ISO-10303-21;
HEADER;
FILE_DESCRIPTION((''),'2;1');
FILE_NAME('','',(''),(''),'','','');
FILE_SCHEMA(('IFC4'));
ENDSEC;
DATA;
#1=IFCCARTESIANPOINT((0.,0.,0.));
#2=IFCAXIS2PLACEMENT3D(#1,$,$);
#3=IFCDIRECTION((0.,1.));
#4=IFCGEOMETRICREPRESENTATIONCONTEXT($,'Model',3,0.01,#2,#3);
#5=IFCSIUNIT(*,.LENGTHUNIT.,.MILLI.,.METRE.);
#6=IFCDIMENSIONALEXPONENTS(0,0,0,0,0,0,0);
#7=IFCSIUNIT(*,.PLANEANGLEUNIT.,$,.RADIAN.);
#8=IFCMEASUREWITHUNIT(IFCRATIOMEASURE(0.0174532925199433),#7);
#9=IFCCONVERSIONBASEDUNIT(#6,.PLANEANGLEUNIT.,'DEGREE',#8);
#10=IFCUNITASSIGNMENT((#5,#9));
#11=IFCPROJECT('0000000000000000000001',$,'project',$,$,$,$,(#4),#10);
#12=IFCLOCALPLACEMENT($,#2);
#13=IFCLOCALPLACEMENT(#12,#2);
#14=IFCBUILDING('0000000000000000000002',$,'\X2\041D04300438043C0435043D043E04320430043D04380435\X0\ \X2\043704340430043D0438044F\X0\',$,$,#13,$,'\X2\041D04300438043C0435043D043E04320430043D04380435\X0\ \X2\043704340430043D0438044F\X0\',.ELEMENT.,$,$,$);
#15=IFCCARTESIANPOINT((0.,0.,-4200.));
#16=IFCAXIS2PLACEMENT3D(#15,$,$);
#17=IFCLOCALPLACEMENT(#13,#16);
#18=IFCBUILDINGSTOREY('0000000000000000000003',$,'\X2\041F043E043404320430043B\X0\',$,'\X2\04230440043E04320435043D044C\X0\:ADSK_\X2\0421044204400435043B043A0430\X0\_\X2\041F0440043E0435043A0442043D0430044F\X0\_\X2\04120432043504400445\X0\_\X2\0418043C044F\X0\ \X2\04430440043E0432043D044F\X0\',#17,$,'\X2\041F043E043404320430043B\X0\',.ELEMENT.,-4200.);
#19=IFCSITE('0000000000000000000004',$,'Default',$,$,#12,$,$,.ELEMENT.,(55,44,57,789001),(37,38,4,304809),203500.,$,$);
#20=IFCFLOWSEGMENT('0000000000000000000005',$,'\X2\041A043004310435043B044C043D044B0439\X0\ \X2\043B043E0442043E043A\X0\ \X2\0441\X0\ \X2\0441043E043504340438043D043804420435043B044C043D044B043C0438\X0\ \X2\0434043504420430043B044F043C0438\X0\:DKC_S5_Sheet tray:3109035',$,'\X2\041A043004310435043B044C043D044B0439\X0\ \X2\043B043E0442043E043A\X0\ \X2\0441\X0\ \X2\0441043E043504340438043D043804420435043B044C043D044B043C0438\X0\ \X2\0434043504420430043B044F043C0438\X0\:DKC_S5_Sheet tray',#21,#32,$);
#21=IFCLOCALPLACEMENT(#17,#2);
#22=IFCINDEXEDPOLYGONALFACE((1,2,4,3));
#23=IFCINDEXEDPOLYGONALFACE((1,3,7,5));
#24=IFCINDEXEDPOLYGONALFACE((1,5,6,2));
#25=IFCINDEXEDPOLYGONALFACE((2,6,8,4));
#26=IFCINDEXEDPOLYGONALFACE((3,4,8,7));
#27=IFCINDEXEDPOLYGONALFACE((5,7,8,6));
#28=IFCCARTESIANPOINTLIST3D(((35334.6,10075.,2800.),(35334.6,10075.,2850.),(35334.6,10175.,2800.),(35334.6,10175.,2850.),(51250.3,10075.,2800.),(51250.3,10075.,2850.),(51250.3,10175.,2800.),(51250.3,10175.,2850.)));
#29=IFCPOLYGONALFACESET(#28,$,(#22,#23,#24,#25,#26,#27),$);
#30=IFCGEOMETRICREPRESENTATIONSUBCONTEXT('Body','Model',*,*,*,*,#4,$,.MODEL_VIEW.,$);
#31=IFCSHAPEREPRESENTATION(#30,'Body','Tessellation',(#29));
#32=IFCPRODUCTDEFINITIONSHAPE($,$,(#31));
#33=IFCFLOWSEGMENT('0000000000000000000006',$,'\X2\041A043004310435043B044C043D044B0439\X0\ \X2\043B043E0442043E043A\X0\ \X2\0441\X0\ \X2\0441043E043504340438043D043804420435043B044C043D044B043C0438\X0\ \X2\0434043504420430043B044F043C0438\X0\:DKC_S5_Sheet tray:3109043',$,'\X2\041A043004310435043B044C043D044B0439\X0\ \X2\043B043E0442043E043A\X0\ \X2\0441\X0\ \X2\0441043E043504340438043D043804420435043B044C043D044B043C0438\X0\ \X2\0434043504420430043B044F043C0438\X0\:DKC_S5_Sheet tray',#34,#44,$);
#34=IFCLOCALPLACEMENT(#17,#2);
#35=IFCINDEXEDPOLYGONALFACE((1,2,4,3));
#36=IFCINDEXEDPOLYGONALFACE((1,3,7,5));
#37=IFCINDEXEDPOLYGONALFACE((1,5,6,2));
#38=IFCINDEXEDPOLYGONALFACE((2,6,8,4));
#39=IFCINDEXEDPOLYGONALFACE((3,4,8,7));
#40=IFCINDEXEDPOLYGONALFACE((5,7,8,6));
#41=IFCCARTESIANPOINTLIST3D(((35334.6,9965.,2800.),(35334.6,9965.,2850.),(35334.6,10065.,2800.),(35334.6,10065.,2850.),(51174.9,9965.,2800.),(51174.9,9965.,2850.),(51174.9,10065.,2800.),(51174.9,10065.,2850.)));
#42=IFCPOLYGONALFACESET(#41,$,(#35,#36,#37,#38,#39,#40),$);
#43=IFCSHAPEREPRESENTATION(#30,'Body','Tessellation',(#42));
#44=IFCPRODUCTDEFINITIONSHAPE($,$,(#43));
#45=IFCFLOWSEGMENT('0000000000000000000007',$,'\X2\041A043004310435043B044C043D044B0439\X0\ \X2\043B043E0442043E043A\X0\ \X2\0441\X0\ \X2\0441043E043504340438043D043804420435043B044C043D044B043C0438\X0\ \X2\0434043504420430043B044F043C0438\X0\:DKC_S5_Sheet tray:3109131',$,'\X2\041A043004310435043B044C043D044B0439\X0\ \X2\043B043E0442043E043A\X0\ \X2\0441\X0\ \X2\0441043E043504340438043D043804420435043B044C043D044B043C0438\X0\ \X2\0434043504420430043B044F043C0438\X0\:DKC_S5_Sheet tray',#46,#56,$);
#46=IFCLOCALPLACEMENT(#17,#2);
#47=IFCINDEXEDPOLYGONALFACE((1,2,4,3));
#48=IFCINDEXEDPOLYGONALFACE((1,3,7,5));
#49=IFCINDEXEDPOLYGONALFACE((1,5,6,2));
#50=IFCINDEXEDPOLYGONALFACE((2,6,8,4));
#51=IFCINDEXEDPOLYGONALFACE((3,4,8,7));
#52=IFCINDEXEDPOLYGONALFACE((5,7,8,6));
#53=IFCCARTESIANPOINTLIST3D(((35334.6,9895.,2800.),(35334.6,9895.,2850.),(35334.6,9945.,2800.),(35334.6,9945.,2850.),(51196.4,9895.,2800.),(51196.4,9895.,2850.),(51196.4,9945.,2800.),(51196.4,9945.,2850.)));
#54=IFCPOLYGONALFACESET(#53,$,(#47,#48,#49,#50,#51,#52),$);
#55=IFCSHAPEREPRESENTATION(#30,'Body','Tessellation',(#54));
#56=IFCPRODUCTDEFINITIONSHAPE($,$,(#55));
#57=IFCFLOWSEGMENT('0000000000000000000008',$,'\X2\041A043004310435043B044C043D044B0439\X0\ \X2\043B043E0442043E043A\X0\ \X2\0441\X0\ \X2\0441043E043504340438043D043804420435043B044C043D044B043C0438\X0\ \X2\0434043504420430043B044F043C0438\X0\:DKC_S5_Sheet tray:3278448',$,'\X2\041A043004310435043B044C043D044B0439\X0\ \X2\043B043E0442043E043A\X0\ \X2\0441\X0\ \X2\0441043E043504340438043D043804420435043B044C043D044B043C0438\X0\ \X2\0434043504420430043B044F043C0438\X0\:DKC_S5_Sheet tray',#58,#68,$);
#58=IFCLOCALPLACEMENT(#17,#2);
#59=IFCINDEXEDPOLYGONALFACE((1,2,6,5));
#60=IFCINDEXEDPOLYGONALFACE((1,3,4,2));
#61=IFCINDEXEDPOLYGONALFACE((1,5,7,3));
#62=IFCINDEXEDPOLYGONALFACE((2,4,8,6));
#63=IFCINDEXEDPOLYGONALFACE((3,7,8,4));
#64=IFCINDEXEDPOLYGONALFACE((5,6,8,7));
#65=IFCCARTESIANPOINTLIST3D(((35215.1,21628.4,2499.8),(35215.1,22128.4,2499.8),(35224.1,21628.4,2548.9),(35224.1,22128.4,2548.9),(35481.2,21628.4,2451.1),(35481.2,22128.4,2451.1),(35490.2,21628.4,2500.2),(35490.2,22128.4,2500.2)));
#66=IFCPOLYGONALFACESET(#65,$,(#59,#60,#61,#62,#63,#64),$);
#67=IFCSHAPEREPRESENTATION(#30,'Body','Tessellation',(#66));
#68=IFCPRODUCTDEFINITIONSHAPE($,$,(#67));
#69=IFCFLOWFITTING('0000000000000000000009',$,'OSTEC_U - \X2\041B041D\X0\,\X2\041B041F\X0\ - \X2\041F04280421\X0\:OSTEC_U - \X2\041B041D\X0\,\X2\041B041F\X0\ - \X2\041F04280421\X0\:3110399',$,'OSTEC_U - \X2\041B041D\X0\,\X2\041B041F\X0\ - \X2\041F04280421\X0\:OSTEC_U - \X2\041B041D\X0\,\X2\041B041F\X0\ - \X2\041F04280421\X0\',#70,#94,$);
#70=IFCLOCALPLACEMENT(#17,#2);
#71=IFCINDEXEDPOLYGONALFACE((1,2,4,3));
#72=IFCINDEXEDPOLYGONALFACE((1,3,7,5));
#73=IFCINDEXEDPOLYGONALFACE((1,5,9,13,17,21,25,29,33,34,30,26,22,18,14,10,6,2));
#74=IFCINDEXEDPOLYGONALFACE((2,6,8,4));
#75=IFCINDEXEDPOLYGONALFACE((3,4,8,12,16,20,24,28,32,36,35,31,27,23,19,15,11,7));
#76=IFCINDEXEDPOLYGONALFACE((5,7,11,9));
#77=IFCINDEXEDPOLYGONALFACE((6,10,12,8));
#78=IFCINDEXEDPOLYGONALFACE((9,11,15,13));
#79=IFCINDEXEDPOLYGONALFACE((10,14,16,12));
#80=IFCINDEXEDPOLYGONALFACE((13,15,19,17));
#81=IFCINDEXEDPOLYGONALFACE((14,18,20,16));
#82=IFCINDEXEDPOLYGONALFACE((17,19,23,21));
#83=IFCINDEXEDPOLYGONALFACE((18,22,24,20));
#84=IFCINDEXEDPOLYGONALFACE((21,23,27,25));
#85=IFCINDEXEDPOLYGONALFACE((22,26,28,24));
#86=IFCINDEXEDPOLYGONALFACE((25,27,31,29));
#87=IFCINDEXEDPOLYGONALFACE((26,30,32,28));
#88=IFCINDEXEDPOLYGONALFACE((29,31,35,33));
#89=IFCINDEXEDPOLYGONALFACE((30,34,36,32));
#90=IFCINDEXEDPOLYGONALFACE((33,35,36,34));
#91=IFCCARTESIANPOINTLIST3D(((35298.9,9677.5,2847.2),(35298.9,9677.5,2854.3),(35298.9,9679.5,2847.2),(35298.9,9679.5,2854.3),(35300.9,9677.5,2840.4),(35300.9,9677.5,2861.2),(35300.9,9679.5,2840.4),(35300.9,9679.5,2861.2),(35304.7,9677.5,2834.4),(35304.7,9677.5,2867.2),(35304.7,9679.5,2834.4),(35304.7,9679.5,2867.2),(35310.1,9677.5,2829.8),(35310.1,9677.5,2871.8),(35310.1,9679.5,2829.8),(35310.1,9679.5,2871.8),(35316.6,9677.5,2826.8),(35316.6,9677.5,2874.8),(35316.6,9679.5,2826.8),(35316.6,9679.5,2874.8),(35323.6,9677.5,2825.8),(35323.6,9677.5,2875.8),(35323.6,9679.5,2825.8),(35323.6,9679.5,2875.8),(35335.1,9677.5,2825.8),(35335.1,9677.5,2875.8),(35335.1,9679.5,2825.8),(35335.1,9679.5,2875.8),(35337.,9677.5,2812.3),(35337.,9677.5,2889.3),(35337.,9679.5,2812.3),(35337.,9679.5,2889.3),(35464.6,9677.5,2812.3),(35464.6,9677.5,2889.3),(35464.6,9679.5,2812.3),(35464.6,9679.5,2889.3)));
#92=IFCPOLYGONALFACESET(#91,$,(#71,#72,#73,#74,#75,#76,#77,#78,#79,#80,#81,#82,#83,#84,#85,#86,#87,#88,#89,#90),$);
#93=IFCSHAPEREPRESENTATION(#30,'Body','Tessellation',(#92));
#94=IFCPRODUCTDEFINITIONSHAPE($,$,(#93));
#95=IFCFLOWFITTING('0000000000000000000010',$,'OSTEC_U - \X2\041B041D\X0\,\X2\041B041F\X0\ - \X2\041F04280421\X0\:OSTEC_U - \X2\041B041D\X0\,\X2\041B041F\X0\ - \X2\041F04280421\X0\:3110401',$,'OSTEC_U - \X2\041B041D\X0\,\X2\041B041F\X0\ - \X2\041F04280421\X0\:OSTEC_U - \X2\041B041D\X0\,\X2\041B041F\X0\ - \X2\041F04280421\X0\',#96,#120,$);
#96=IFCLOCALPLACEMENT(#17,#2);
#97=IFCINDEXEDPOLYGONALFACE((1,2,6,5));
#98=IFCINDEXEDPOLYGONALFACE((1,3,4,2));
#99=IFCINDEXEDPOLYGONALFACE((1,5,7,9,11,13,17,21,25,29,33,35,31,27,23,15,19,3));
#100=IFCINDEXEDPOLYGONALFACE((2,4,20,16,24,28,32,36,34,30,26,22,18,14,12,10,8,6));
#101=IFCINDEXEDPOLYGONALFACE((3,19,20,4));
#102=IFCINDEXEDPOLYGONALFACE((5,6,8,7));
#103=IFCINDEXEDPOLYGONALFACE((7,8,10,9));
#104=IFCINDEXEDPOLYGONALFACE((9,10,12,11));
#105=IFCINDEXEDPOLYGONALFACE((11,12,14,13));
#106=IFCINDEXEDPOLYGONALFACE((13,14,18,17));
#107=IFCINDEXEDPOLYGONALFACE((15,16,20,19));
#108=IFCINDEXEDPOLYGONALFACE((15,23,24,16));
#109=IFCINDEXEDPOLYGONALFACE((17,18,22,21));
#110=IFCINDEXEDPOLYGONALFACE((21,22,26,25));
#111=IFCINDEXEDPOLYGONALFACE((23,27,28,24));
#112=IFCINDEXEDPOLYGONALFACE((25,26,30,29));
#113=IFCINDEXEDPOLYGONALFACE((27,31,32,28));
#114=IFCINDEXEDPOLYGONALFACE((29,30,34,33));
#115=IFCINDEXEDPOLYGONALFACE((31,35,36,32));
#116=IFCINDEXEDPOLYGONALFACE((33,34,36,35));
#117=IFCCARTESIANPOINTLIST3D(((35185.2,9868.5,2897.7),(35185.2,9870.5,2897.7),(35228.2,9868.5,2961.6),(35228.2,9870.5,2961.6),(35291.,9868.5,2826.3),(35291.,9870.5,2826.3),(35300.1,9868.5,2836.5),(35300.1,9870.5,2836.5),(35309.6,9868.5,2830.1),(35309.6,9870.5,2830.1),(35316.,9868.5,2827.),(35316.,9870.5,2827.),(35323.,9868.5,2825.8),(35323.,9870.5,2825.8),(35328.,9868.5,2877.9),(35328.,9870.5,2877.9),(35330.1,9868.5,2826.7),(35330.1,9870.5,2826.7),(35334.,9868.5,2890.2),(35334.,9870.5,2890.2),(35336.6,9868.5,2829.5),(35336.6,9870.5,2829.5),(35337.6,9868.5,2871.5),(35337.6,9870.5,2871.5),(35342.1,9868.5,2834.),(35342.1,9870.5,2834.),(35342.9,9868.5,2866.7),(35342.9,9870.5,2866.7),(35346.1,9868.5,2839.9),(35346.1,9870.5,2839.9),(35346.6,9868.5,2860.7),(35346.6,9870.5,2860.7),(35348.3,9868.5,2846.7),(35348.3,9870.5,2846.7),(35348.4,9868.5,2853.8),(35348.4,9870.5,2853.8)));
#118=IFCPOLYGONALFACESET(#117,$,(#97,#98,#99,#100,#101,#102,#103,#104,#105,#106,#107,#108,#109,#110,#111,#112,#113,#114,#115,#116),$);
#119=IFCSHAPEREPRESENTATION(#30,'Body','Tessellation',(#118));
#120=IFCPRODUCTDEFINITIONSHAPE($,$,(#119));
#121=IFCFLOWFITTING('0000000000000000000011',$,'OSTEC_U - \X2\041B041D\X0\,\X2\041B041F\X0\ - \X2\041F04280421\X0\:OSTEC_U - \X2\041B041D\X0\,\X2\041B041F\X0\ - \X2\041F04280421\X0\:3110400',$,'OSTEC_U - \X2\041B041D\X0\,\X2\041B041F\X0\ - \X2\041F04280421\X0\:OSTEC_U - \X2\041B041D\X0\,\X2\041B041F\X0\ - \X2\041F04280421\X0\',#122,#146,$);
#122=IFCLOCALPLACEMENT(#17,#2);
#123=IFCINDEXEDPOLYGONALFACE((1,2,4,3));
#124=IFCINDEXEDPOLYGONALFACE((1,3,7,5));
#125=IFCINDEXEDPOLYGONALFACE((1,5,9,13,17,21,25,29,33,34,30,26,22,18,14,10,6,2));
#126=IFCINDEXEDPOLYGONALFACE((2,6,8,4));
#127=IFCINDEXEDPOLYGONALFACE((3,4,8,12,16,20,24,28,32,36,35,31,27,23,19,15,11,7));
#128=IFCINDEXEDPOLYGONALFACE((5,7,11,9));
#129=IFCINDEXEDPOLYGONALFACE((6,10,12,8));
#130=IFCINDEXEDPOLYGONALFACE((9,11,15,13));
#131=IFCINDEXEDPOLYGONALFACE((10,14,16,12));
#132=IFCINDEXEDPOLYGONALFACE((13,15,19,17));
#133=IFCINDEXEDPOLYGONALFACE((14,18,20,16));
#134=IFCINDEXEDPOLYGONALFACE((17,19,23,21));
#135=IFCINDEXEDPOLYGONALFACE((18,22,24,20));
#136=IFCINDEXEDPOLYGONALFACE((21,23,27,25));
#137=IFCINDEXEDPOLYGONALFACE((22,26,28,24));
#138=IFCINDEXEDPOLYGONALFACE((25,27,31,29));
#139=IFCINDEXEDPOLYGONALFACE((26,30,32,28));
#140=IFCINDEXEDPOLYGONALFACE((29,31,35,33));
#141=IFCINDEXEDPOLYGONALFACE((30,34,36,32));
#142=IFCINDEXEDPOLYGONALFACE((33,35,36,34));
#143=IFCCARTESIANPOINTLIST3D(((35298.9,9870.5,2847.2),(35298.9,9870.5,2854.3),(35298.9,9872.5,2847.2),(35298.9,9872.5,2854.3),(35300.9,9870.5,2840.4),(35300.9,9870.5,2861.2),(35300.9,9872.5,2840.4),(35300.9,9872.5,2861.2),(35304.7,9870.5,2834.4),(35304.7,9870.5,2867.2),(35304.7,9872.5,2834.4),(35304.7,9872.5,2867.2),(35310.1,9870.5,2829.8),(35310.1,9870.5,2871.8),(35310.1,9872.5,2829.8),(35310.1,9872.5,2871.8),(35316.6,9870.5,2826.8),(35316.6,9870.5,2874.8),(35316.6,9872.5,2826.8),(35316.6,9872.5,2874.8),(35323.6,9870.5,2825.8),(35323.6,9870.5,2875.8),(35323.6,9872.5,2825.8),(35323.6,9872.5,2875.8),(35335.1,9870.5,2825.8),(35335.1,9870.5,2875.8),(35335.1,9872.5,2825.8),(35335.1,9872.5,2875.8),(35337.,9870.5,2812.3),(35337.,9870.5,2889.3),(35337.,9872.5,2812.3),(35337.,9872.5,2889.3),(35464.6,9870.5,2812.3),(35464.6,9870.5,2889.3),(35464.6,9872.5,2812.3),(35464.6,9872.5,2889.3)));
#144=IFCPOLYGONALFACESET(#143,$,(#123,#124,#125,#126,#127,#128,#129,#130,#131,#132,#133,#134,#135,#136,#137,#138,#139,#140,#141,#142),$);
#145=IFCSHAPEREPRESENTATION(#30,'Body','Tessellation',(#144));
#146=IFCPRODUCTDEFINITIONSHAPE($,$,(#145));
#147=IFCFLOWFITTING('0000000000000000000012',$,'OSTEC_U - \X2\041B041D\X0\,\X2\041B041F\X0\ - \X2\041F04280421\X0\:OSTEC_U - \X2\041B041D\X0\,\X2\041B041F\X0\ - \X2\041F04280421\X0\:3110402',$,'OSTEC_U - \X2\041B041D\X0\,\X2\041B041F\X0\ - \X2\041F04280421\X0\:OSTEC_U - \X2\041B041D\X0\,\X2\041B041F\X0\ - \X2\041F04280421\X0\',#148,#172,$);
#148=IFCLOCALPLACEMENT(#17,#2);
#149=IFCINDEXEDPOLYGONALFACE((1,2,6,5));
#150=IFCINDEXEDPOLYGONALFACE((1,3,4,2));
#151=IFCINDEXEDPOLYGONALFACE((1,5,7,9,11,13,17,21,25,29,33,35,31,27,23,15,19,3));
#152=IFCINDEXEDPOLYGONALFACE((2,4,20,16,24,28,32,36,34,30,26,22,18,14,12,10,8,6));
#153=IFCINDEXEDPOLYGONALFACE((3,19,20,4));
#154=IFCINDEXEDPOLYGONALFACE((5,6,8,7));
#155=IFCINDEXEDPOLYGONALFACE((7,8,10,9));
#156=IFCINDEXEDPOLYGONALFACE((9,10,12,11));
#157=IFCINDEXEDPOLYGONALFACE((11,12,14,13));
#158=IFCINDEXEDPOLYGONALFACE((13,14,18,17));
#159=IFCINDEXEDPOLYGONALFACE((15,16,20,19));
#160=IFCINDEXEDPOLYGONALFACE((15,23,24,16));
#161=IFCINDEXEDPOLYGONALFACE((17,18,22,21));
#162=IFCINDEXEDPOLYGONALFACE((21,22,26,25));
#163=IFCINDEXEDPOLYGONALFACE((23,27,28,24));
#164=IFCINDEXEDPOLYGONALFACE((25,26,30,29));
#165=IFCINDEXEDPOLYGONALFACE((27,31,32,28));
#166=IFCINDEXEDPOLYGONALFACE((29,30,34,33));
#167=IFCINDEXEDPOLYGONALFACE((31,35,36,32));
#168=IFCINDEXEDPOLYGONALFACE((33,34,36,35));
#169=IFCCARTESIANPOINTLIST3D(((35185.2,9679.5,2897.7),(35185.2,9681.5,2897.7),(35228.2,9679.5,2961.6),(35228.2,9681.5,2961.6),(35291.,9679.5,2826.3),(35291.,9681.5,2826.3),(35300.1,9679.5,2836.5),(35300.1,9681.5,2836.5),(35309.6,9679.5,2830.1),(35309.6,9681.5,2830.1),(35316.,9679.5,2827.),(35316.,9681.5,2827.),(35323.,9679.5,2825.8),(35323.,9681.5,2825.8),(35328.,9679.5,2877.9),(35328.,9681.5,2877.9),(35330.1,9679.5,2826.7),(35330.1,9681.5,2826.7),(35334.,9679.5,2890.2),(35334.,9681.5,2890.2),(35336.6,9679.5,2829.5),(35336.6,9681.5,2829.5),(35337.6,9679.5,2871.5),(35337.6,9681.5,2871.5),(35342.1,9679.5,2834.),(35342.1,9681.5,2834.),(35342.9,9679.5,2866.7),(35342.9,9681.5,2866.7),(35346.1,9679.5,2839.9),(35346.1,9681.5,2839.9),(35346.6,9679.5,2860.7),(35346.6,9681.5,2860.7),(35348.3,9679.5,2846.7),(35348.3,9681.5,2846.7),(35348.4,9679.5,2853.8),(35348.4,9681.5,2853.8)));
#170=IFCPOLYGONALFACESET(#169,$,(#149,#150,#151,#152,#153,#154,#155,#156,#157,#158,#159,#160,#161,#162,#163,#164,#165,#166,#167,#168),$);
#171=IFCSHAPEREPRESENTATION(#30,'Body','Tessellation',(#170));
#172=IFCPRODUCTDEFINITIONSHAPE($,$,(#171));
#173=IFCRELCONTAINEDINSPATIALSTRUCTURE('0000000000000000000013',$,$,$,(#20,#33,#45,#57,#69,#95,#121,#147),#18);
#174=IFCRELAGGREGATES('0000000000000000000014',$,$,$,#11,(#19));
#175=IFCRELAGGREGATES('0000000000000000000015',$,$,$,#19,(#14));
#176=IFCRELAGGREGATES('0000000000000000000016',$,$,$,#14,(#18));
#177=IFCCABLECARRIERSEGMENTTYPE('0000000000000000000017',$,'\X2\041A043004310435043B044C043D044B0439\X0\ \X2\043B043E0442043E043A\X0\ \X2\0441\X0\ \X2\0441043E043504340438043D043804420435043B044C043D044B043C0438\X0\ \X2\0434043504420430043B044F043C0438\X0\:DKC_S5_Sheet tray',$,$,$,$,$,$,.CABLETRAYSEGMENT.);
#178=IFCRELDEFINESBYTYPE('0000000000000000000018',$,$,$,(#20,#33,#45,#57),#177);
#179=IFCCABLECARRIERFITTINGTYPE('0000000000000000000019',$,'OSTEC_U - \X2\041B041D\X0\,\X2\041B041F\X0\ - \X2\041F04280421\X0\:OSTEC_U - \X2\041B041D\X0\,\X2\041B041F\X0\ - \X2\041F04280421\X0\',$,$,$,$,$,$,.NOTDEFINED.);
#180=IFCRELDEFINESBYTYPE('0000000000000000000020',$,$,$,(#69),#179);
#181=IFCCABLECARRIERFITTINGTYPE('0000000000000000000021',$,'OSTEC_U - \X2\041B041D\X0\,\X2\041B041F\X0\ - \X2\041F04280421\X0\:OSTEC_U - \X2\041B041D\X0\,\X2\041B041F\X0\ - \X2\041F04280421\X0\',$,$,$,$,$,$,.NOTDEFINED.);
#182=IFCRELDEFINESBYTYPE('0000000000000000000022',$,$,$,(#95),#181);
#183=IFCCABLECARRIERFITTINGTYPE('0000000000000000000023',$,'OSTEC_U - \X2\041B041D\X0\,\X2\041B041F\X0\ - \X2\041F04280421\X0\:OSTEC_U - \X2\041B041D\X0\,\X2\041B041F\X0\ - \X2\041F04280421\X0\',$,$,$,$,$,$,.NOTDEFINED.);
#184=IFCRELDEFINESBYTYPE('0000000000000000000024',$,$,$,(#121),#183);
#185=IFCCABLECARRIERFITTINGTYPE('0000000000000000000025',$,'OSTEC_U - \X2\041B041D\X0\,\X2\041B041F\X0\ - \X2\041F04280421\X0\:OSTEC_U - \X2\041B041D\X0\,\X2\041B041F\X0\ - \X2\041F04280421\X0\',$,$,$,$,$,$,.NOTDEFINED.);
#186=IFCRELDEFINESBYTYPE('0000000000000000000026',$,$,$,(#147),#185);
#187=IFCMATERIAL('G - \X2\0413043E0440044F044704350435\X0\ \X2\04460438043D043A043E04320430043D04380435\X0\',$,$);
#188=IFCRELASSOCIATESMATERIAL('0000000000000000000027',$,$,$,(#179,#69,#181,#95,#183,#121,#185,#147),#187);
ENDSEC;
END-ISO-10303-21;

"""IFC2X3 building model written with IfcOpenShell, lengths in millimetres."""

from ifc_helpers import new_model, entity, si_unit, converted_unit, direction, frame, frame_2d, origin, origin_2d_with_axis, place, context, subcontext, project, spatial, polyline, circle_curve, parameter, trimmed, segment, composite_curve, rectangle, outline, extrude, source, transform, mapped, material, type_object, type_shapes, element, save


model = new_model("IFC2X3")

# Units and contexts
model_context = context("Model", 3, precision=0.01, world=origin(), true_north=direction((0.0, 1.0)))
body_context = subcontext(model_context, "Body", "Model", "MODEL_VIEW")
ifc_project = project(units=[si_unit("LENGTHUNIT", "METRE", prefix="MILLI"), converted_unit("PLANEANGLEUNIT", "DEGREE", entity("IfcRatioMeasure", 0.0174532925199433), si_unit("PLANEANGLEUNIT", "RADIAN"), dimensions=[0, 0, 0, 0, 0, 0, 0])], contexts=[model_context])

# Site, building, storey
site_placement = place(None, origin())
site = spatial("IfcSite", under=ifc_project, at=site_placement, Name="Default", CompositionType="ELEMENT", RefLatitude=(55, 44, 57, 789001), RefLongitude=(37, 38, 4, 304809), RefElevation=203500.0)
building_placement = place(site_placement, origin())
building = spatial("IfcBuilding", under=site, at=building_placement, Name="Наименование здания", LongName="Наименование здания", CompositionType="ELEMENT")
storey_placement = place(building_placement, frame((0.0, 0.0, -4200.0)))
storey = spatial("IfcBuildingStorey", under=building, at=storey_placement, Name="Подвал", ObjectType="Уровень:ADSK_Стрелка_Проектная_Вверх_Имя уровня", LongName="Подвал", CompositionType="ELEMENT", Elevation=-4200.0)

# Flow segments
cable_carrier_segment_type = type_object("IfcCableCarrierSegmentType", Name="Кабельный лоток с соединительными деталями:DKC_S5_Sheet tray", PredefinedType="CABLETRAYSEGMENT")
flow_segment_1_placement = place(storey_placement, frame((35334.6, 10075.0, 2800.0)))
element("IfcFlowSegment", 1, at=flow_segment_1_placement, inside=storey, type_object=cable_carrier_segment_type, Name="Кабельный лоток с соединительными деталями:DKC_S5_Sheet tray:3109035", ObjectType="Кабельный лоток с соединительными деталями:DKC_S5_Sheet tray", context=body_context, shape_type="SweptSolid", body=[
    extrude(rectangle(XDim=15915.7, YDim=100.0, at=origin_2d_with_axis()), frame((7957.8, 50.0, 0.0)), (0.0, 0.0, 1.0), 50.0),
])
flow_segment_2_placement = place(storey_placement, frame((35334.6, 9965.0, 2800.0)))
element("IfcFlowSegment", 2, at=flow_segment_2_placement, inside=storey, type_object=cable_carrier_segment_type, Name="Кабельный лоток с соединительными деталями:DKC_S5_Sheet tray:3109043", ObjectType="Кабельный лоток с соединительными деталями:DKC_S5_Sheet tray", context=body_context, shape_type="SweptSolid", body=[
    extrude(rectangle(XDim=15840.3, YDim=100.0, at=origin_2d_with_axis()), frame((7920.1, 50.0, 0.0)), (0.0, 0.0, 1.0), 50.0),
])
flow_segment_3_placement = place(storey_placement, frame((35334.6, 9895.0, 2800.0)))
element("IfcFlowSegment", 3, at=flow_segment_3_placement, inside=storey, type_object=cable_carrier_segment_type, Name="Кабельный лоток с соединительными деталями:DKC_S5_Sheet tray:3109131", ObjectType="Кабельный лоток с соединительными деталями:DKC_S5_Sheet tray", context=body_context, shape_type="SweptSolid", body=[
    extrude(rectangle(XDim=15861.8, YDim=50.0, at=origin_2d_with_axis()), frame((7930.9, 25.0, 0.0)), (0.0, 0.0, 1.0), 50.0),
])
flow_segment_4_placement = place(storey_placement, frame((35215.1, 21628.4, 2451.1)))
element("IfcFlowSegment", 4, at=flow_segment_4_placement, inside=storey, type_object=cable_carrier_segment_type, Name="Кабельный лоток с соединительными деталями:DKC_S5_Sheet tray:3278448", ObjectType="Кабельный лоток с соединительными деталями:DKC_S5_Sheet tray", context=body_context, shape_type="SweptSolid", body=[
    extrude(rectangle(XDim=50.0, YDim=270.5, at=frame_2d((0.0, 0.0), x_axis=(0.0, 1.0))), frame((137.5, 0.0, 48.9), z_axis=(0.0, 1.0, 0.0), x_axis=(0.983663, 0.0, -0.18002)), (0.0, 0.0, 1.0), 500.0),
])

# Flow fittings
ifc_material = material(Name="G - Горячее цинкование")
cable_carrier_fitting_type_1 = type_object("IfcCableCarrierFittingType", Name="OSTEC_U - ЛН,ЛП - ПШС:OSTEC_U - ЛН,ЛП - ПШС", PredefinedType="NOTDEFINED", material=ifc_material)
shared_shape_1 = source(origin(), body_context, "Body", "SweptSolid", [
    extrude(outline(composite_curve([segment(trimmed(circle_curve(frame_2d((-41.5, 0.0), x_axis=(1.0, 0.0)), 25.0), [parameter(90.0)], [parameter(270.0)], True, "PARAMETER"), True, "CONTINUOUS"), segment(polyline([(-41.5, -25.0), (-30.0, -25.0)]), True, "CONTINUOUS"), segment(polyline([(-30.0, -25.0), (-28.1, -38.5)]), True, "CONTINUOUS"), segment(polyline([(-28.1, -38.5), (99.5, -38.5)]), True, "CONTINUOUS"), segment(polyline([(99.5, -38.5), (99.5, 38.5)]), True, "CONTINUOUS"), segment(polyline([(99.5, 38.5), (-28.1, 38.5)]), True, "CONTINUOUS"), segment(polyline([(-28.1, 38.5), (-30.0, 25.0)]), True, "CONTINUOUS"), segment(polyline([(-30.0, 25.0), (-41.5, 25.0)]), True, "CONTINUOUS")], self_intersect=False)), frame((41.5, 0.0, 0.0), z_axis=(0.0, 0.0, -1.0), x_axis=(1.0, 0.0, 0.0)), (0.0, 0.0, -1.0), 2.0),
])
type_shapes(cable_carrier_fitting_type_1, [shared_shape_1])
flow_fitting_1_placement = place(storey_placement, frame((35323.6, 9679.5, 2850.8), z_axis=(0.0, -1.0, 0.0), x_axis=(1.0, 0.0, -0.00005)))
element("IfcFlowFitting", 5, at=flow_fitting_1_placement, inside=storey, type_object=cable_carrier_fitting_type_1, material=ifc_material, Name="OSTEC_U - ЛН,ЛП - ПШС:OSTEC_U - ЛН,ЛП - ПШС:3110399", ObjectType="OSTEC_U - ЛН,ЛП - ПШС:OSTEC_U - ЛН,ЛП - ПШС", context=body_context, shape_type="MappedRepresentation", body=[
    mapped(shared_shape_1, transform((0.0, 0.0, 0.0), scale=1.0)),
])
cable_carrier_fitting_type_2 = type_object("IfcCableCarrierFittingType", Name="OSTEC_U - ЛН,ЛП - ПШС:OSTEC_U - ЛН,ЛП - ПШС", PredefinedType="NOTDEFINED", material=ifc_material)
type_shapes(cable_carrier_fitting_type_2, [shared_shape_1])
flow_fitting_2_placement = place(storey_placement, frame((35323.6, 9868.5, 2850.8), z_axis=(0.0, 1.0, 0.0), x_axis=(-0.829038, 0.0, 0.559193)))
element("IfcFlowFitting", 6, at=flow_fitting_2_placement, inside=storey, type_object=cable_carrier_fitting_type_2, material=ifc_material, Name="OSTEC_U - ЛН,ЛП - ПШС:OSTEC_U - ЛН,ЛП - ПШС:3110401", ObjectType="OSTEC_U - ЛН,ЛП - ПШС:OSTEC_U - ЛН,ЛП - ПШС", context=body_context, shape_type="MappedRepresentation", body=[
    mapped(shared_shape_1, transform((0.0, 0.0, 0.0), scale=1.0)),
])
cable_carrier_fitting_type_3 = type_object("IfcCableCarrierFittingType", Name="OSTEC_U - ЛН,ЛП - ПШС:OSTEC_U - ЛН,ЛП - ПШС", PredefinedType="NOTDEFINED", material=ifc_material)
shared_shape_2 = source(origin(), body_context, "Body", "SweptSolid", [
    extrude(outline(composite_curve([segment(trimmed(circle_curve(frame_2d((-41.5, 0.0), x_axis=(1.0, 0.0)), 25.0), [parameter(90.0)], [parameter(270.0)], True, "PARAMETER"), True, "CONTINUOUS"), segment(polyline([(-41.5, -25.0), (-30.0, -25.0)]), True, "CONTINUOUS"), segment(polyline([(-30.0, -25.0), (-28.1, -38.5)]), True, "CONTINUOUS"), segment(polyline([(-28.1, -38.5), (99.5, -38.5)]), True, "CONTINUOUS"), segment(polyline([(99.5, -38.5), (99.5, 38.5)]), True, "CONTINUOUS"), segment(polyline([(99.5, 38.5), (-28.1, 38.5)]), True, "CONTINUOUS"), segment(polyline([(-28.1, 38.5), (-30.0, 25.0)]), True, "CONTINUOUS"), segment(polyline([(-30.0, 25.0), (-41.5, 25.0)]), True, "CONTINUOUS")], self_intersect=False)), frame((41.5, 0.0, 0.0)), (0.0, 0.0, 1.0), 2.0),
])
type_shapes(cable_carrier_fitting_type_3, [shared_shape_2])
flow_fitting_3_placement = place(storey_placement, frame((35323.6, 9870.5, 2850.8), z_axis=(0.0, 1.0, 0.0), x_axis=(1.0, 0.0, -0.00005)))
element("IfcFlowFitting", 7, at=flow_fitting_3_placement, inside=storey, type_object=cable_carrier_fitting_type_3, material=ifc_material, Name="OSTEC_U - ЛН,ЛП - ПШС:OSTEC_U - ЛН,ЛП - ПШС:3110400", ObjectType="OSTEC_U - ЛН,ЛП - ПШС:OSTEC_U - ЛН,ЛП - ПШС", context=body_context, shape_type="MappedRepresentation", body=[
    mapped(shared_shape_2, transform((0.0, 0.0, 0.0), scale=1.0)),
])
cable_carrier_fitting_type_4 = type_object("IfcCableCarrierFittingType", Name="OSTEC_U - ЛН,ЛП - ПШС:OSTEC_U - ЛН,ЛП - ПШС", PredefinedType="NOTDEFINED", material=ifc_material)
type_shapes(cable_carrier_fitting_type_4, [shared_shape_2])
flow_fitting_4_placement = place(storey_placement, frame((35323.6, 9681.5, 2850.8), z_axis=(0.0, -1.0, 0.0), x_axis=(-0.829038, 0.0, 0.559193)))
element("IfcFlowFitting", 8, at=flow_fitting_4_placement, inside=storey, type_object=cable_carrier_fitting_type_4, material=ifc_material, Name="OSTEC_U - ЛН,ЛП - ПШС:OSTEC_U - ЛН,ЛП - ПШС:3110402", ObjectType="OSTEC_U - ЛН,ЛП - ПШС:OSTEC_U - ЛН,ЛП - ПШС", context=body_context, shape_type="MappedRepresentation", body=[
    mapped(shared_shape_2, transform((0.0, 0.0, 0.0), scale=1.0)),
])

save(model, "model.ifc")
